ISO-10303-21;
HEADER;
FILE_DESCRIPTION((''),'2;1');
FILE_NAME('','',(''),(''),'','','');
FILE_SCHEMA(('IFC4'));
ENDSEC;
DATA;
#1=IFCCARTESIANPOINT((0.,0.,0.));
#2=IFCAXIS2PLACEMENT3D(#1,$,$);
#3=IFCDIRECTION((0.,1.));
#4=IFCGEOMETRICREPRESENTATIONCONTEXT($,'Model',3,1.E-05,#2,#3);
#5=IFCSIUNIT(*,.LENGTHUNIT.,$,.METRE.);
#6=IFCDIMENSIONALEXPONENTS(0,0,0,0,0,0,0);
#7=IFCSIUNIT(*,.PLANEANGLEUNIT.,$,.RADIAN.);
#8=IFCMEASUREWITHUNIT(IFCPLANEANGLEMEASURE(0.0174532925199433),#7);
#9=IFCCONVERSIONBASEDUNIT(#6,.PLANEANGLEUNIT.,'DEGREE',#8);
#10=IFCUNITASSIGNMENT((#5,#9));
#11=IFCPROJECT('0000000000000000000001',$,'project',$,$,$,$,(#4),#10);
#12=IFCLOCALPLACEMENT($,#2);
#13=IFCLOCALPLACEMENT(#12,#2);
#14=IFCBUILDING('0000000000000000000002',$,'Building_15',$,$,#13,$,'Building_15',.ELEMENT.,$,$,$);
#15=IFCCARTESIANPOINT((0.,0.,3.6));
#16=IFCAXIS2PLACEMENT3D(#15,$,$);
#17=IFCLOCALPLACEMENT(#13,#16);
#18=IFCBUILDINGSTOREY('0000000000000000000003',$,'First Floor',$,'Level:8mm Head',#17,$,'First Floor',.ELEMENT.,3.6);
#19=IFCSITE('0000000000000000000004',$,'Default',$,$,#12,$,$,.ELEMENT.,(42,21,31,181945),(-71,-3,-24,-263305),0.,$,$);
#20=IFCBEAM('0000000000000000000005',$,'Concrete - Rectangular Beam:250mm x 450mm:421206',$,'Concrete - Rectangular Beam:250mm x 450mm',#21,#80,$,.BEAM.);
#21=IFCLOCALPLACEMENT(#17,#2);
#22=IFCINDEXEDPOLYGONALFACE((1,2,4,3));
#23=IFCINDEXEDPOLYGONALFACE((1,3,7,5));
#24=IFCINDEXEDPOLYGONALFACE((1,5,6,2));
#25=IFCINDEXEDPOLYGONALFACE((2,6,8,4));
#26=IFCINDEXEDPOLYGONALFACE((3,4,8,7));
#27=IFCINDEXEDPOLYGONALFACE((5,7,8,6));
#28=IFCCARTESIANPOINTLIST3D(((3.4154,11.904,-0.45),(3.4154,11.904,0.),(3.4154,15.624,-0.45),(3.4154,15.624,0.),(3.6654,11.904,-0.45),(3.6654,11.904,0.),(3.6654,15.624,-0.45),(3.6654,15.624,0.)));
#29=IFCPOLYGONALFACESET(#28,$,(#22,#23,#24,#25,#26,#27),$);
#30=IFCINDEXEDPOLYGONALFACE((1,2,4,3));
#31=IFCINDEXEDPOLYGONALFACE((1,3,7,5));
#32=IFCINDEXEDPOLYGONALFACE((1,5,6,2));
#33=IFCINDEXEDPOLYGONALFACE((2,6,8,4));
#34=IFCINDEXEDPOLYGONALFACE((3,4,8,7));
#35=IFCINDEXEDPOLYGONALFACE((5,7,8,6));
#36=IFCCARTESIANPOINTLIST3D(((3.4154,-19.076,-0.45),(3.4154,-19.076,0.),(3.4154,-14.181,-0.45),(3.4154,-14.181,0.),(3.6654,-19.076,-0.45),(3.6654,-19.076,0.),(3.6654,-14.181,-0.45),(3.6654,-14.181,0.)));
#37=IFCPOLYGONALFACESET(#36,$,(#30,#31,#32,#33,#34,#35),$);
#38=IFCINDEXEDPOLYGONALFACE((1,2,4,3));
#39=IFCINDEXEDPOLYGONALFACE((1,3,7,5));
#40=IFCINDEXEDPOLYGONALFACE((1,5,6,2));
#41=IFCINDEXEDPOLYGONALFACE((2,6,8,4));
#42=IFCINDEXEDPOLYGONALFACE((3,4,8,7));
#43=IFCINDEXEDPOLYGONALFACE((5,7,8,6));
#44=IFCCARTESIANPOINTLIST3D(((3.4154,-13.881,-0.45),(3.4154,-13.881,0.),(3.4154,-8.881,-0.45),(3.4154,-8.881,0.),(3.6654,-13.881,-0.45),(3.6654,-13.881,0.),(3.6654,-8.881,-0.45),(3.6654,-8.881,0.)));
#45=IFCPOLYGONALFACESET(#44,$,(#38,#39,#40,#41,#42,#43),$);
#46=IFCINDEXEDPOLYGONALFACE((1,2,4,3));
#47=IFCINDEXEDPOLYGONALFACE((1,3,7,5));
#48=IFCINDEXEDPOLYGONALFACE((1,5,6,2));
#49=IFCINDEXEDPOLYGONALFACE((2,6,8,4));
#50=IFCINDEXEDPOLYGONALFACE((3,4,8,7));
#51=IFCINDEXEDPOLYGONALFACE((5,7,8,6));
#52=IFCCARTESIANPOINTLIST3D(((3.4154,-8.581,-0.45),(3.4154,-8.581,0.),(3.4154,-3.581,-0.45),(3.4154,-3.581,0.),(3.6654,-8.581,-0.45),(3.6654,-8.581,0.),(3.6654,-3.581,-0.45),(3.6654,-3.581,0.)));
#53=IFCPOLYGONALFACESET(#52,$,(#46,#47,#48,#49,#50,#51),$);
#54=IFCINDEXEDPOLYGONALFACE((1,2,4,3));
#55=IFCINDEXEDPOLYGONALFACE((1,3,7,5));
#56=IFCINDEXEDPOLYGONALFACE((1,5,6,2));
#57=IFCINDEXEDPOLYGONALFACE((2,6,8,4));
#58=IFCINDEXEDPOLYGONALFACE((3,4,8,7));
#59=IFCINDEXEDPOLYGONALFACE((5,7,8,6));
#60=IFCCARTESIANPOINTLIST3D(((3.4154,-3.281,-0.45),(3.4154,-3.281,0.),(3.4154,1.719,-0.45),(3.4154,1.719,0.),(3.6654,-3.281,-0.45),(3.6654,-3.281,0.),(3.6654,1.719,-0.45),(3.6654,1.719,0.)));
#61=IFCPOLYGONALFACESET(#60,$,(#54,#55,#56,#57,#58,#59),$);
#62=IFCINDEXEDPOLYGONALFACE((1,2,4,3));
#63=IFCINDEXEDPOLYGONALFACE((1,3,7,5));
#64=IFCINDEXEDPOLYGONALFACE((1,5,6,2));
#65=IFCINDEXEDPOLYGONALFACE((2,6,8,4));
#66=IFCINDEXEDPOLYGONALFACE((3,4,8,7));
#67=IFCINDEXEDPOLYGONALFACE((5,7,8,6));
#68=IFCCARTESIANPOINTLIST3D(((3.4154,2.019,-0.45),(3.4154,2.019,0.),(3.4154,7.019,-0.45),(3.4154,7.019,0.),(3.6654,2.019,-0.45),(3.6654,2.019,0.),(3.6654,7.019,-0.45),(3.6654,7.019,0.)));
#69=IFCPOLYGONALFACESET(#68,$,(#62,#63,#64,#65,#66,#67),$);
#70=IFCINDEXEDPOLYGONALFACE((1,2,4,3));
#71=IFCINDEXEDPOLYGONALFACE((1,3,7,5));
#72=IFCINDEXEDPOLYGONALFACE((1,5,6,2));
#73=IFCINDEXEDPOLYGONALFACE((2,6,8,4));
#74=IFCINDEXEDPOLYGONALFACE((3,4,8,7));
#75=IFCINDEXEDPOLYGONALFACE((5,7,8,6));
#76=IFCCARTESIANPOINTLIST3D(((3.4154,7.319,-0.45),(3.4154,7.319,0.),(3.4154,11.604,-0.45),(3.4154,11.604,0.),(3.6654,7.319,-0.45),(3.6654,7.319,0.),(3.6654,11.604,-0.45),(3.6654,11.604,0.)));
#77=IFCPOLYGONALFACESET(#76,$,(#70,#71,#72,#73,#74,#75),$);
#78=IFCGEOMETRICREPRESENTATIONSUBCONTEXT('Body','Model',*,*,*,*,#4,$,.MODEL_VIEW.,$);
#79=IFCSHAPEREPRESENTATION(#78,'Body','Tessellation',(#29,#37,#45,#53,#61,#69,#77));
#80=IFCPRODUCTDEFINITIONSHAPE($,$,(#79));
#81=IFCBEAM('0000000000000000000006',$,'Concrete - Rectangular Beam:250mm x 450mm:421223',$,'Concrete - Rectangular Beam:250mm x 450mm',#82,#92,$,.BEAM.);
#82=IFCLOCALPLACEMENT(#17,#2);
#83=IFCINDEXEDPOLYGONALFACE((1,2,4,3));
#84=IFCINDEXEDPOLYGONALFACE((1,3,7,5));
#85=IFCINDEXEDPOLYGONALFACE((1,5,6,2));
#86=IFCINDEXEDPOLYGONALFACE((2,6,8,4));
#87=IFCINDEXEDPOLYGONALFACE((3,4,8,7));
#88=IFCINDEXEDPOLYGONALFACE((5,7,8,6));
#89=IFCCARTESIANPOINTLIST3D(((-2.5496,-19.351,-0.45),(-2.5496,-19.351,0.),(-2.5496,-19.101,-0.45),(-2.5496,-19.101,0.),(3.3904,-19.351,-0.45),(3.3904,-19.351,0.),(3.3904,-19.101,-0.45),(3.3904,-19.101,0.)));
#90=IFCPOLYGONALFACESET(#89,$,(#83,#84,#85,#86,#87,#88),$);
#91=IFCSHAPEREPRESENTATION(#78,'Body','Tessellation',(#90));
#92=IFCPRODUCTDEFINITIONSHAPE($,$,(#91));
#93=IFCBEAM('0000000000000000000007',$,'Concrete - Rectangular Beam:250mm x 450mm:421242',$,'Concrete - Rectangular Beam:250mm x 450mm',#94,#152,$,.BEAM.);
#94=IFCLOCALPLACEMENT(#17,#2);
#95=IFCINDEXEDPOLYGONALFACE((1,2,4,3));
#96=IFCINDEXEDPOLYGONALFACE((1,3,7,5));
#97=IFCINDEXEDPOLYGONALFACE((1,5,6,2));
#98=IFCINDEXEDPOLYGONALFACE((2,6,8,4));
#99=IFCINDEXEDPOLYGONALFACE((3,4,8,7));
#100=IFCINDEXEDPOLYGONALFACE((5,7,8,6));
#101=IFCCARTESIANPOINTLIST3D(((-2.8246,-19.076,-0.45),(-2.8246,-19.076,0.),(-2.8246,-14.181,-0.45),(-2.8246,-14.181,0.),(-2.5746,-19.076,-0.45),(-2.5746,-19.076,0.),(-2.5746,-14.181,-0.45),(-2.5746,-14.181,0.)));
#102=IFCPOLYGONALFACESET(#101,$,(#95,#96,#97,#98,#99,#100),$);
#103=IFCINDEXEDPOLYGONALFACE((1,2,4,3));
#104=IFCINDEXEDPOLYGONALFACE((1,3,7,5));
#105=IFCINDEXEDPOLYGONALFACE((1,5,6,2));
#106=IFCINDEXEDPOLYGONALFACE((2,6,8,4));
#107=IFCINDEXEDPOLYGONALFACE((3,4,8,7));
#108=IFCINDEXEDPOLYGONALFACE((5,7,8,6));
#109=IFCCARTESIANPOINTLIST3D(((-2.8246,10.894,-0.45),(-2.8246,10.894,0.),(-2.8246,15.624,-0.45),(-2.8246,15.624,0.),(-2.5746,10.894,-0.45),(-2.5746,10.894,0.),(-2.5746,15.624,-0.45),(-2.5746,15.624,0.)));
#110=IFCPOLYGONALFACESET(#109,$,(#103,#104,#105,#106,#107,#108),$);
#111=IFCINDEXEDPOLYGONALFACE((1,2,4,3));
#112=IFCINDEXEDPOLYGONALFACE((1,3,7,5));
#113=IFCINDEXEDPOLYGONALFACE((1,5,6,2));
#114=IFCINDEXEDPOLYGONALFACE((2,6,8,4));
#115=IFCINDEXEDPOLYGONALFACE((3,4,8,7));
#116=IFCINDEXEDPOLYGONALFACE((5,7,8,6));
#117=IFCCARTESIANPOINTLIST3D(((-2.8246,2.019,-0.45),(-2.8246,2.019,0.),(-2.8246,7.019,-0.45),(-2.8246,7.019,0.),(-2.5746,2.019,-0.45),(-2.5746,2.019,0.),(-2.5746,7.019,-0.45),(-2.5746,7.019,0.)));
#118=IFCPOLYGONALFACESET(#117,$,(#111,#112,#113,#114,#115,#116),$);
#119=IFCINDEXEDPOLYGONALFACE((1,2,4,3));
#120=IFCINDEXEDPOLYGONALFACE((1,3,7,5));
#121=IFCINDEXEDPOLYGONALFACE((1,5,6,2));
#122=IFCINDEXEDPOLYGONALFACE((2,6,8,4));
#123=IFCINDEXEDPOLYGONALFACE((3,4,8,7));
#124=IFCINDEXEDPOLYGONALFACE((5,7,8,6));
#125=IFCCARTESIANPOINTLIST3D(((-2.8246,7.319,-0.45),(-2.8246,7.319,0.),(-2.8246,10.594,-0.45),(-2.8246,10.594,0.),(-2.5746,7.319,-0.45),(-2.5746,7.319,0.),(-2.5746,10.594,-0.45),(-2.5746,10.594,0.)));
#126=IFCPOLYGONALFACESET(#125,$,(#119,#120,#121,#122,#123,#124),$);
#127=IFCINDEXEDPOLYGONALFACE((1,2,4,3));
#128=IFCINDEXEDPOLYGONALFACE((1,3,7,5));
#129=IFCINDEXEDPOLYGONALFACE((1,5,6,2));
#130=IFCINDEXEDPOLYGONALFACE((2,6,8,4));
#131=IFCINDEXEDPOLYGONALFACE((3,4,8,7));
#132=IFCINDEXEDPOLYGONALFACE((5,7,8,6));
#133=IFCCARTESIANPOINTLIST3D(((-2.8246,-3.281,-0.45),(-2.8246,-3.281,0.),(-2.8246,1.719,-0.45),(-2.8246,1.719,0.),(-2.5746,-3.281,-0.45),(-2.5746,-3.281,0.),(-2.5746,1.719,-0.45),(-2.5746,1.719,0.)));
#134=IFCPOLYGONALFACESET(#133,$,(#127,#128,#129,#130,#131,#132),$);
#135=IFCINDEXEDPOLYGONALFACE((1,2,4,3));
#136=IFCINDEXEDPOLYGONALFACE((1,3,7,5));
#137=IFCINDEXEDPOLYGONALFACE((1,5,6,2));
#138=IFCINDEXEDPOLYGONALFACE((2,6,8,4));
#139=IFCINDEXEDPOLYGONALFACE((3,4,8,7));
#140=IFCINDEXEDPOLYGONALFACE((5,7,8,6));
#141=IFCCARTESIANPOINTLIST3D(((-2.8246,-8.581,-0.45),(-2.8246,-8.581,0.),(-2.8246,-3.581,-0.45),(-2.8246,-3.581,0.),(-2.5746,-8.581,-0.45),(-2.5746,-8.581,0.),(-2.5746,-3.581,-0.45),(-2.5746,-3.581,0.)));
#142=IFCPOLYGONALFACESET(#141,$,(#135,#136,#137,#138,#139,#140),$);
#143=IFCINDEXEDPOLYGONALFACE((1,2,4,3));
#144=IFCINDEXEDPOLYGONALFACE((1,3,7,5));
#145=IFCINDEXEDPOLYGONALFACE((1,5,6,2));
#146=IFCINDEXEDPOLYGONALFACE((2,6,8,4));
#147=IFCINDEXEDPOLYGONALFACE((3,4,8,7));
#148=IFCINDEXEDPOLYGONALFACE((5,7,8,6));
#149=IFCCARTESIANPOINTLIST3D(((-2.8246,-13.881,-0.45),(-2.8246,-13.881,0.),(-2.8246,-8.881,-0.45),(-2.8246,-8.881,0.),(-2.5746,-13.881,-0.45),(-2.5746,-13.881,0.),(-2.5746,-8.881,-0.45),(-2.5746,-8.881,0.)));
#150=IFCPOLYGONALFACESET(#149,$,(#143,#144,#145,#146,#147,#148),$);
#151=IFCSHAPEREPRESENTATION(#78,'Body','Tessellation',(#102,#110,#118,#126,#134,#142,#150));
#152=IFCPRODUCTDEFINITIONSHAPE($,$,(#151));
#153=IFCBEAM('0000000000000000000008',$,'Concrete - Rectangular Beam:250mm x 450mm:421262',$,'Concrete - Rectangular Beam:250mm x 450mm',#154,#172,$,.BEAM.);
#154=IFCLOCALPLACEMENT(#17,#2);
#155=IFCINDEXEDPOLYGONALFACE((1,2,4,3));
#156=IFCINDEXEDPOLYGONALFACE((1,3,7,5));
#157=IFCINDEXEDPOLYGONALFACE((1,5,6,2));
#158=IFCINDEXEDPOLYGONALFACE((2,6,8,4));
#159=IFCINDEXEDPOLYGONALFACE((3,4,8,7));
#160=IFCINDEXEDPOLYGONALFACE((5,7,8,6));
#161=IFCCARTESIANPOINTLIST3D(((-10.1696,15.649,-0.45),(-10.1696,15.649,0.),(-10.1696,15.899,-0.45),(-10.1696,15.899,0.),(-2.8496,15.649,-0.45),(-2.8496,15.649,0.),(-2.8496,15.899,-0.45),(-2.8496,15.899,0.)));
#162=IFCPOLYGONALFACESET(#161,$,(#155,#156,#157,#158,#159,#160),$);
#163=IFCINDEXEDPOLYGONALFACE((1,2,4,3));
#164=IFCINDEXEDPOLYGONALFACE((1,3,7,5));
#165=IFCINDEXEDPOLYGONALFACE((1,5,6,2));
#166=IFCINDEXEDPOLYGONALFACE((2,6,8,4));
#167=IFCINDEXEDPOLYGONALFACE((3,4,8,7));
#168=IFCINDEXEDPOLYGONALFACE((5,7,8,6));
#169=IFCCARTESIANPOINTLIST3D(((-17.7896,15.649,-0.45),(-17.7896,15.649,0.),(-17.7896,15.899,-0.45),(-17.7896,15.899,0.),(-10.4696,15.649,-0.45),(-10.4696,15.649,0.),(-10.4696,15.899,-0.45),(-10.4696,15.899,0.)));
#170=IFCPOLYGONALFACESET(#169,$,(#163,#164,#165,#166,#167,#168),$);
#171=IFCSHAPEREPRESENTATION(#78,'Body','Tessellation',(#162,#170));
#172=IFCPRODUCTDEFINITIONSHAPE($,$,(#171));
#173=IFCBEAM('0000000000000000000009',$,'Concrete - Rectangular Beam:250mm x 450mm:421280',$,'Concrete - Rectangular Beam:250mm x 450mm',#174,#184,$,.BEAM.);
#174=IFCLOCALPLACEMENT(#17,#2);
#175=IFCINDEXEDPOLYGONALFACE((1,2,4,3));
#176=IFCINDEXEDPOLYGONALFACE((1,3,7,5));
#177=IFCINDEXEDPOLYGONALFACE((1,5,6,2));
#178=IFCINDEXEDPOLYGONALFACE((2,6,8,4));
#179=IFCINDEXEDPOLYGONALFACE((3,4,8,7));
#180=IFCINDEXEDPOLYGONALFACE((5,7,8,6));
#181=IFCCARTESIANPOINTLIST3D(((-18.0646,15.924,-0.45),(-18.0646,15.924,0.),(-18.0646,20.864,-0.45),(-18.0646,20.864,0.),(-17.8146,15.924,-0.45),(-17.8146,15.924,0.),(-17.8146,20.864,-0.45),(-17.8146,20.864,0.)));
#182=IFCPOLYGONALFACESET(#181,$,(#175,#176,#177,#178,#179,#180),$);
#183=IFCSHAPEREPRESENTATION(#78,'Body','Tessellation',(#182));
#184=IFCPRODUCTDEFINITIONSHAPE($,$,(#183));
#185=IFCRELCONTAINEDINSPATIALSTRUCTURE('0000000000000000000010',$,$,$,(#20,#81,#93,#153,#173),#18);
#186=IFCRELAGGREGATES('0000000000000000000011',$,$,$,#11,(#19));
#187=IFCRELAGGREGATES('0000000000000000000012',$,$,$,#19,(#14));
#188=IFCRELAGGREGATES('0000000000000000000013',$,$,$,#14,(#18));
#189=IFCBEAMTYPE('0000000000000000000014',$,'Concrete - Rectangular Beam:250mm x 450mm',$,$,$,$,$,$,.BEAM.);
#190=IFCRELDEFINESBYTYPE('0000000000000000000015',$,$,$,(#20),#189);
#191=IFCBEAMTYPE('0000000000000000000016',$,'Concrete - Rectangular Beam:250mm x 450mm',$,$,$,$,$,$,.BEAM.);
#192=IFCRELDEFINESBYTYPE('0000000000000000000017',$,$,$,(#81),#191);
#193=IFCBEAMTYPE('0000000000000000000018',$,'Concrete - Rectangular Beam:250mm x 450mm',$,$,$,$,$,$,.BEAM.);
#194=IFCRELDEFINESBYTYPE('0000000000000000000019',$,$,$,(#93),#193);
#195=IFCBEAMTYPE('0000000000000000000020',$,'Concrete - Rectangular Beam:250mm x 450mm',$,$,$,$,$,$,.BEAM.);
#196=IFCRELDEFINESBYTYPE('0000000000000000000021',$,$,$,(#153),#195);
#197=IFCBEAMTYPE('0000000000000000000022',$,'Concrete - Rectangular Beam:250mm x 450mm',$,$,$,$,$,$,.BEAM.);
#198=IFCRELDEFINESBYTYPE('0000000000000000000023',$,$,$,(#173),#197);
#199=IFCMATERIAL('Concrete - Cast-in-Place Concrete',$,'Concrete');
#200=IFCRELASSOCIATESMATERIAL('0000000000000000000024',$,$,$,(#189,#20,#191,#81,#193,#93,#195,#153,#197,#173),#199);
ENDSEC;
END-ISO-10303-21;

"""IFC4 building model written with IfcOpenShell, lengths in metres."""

from ifc_helpers import new_model, entity, si_unit, converted_unit, direction, frame, origin, place, context, subcontext, project, spatial, indexed_curve, outline, extrude, source, transform, mapped, material, type_object, type_shapes, element, save


model = new_model("IFC4")

# Units and contexts
model_context = context("Model", 3, precision=1e-05, world=origin(), true_north=direction((0.0, 1.0)))
body_context = subcontext(model_context, "Body", "Model", "MODEL_VIEW")
ifc_project = project(units=[si_unit("LENGTHUNIT", "METRE"), converted_unit("PLANEANGLEUNIT", "DEGREE", entity("IfcPlaneAngleMeasure", 0.0174532925199433), si_unit("PLANEANGLEUNIT", "RADIAN"), dimensions=[0, 0, 0, 0, 0, 0, 0])], contexts=[model_context])

# Site, building, storey
site_placement = place(None, origin())
site = spatial("IfcSite", under=ifc_project, at=site_placement, Name="Default", CompositionType="ELEMENT", RefLatitude=(42, 21, 31, 181945), RefLongitude=(-71, -3, -24, -263305), RefElevation=0.0)
building_placement = place(site_placement, origin())
building = spatial("IfcBuilding", under=site, at=building_placement, Name="Building_15", LongName="Building_15", CompositionType="ELEMENT")
storey_placement = place(building_placement, frame((0.0, 0.0, 3.6)))
storey = spatial("IfcBuildingStorey", under=building, at=storey_placement, Name="First Floor", ObjectType="Level:8mm Head", LongName="First Floor", CompositionType="ELEMENT", Elevation=3.6)

# Beams
ifc_material_1 = material(Name="Concrete - Cast-in-Place Concrete", Category="Concrete")
beam_type_1 = type_object("IfcBeamType", Name="Concrete - Rectangular Beam:250mm x 450mm", PredefinedType="BEAM", material=ifc_material_1)
shared_shape_1 = source(origin(), body_context, "Body", "SweptSolid", [
    extrude(outline(indexed_curve([(-0.125, -0.225), (0.125, -0.225), (0.125, 0.225), (-0.125, 0.225), (-0.125, -0.225)], self_intersect=False)), frame((3.5404, 15.624, 3.375), z_axis=(0.0, -1.0, 0.0), x_axis=(-1.0, 0.0, 0.0)), (0.0, 0.0, 1.0), 3.72),
    extrude(outline(indexed_curve([(-0.125, -0.225), (0.125, -0.225), (0.125, 0.225), (-0.125, 0.225), (-0.125, -0.225)], self_intersect=False)), frame((3.5404, -14.181, 3.375), z_axis=(0.0, -1.0, 0.0), x_axis=(-1.0, 0.0, 0.0)), (0.0, 0.0, 1.0), 4.895),
    extrude(outline(indexed_curve([(-0.125, -0.225), (0.125, -0.225), (0.125, 0.225), (-0.125, 0.225), (-0.125, -0.225)], self_intersect=False)), frame((3.5404, -8.881, 3.375), z_axis=(0.0, -1.0, 0.0), x_axis=(-1.0, 0.0, 0.0)), (0.0, 0.0, 1.0), 5.0),
    extrude(outline(indexed_curve([(-0.125, -0.225), (0.125, -0.225), (0.125, 0.225), (-0.125, 0.225), (-0.125, -0.225)], self_intersect=False)), frame((3.5404, -3.581, 3.375), z_axis=(0.0, -1.0, 0.0), x_axis=(-1.0, 0.0, 0.0)), (0.0, 0.0, 1.0), 5.0),
    extrude(outline(indexed_curve([(-0.125, -0.225), (0.125, -0.225), (0.125, 0.225), (-0.125, 0.225), (-0.125, -0.225)], self_intersect=False)), frame((3.5404, 1.719, 3.375), z_axis=(0.0, -1.0, 0.0), x_axis=(-1.0, 0.0, 0.0)), (0.0, 0.0, 1.0), 5.0),
    extrude(outline(indexed_curve([(-0.125, -0.225), (0.125, -0.225), (0.125, 0.225), (-0.125, 0.225), (-0.125, -0.225)], self_intersect=False)), frame((3.5404, 7.019, 3.375), z_axis=(0.0, -1.0, 0.0), x_axis=(-1.0, 0.0, 0.0)), (0.0, 0.0, 1.0), 5.0),
    extrude(outline(indexed_curve([(-0.125, -0.225), (0.125, -0.225), (0.125, 0.225), (-0.125, 0.225), (-0.125, -0.225)], self_intersect=False)), frame((3.5404, 11.604, 3.375), z_axis=(0.0, -1.0, 0.0), x_axis=(-1.0, 0.0, 0.0)), (0.0, 0.0, 1.0), 4.285),
])
type_shapes(beam_type_1, [shared_shape_1])
beam_1_placement = place(storey_placement, frame((0.0, 0.0, -3.6)))
element("IfcBeam", 1, at=beam_1_placement, inside=storey, type_object=beam_type_1, material=ifc_material_1, Name="Concrete - Rectangular Beam:250mm x 450mm:421206", ObjectType="Concrete - Rectangular Beam:250mm x 450mm", PredefinedType="BEAM", context=body_context, shape_type="MappedRepresentation", body=[
    mapped(shared_shape_1, transform((0.0, 0.0, 0.0), scale=1.0)),
])
beam_type_2 = type_object("IfcBeamType", Name="Concrete - Rectangular Beam:250mm x 450mm", PredefinedType="BEAM", material=ifc_material_1)
shared_shape_2 = source(origin(), body_context, "Body", "SweptSolid", [
    extrude(outline(indexed_curve([(-0.225, -0.125), (0.225, -0.125), (0.225, 0.125), (-0.225, 0.125), (-0.225, -0.125)], self_intersect=False)), frame((3.3904, -19.226, 3.375), z_axis=(-1.0, 0.0, 0.0), x_axis=(0.0, 0.0, -1.0)), (0.0, 0.0, 1.0), 5.94),
])
type_shapes(beam_type_2, [shared_shape_2])
beam_2_placement = place(storey_placement, frame((0.0, 0.0, -3.6)))
element("IfcBeam", 2, at=beam_2_placement, inside=storey, type_object=beam_type_2, material=ifc_material_1, Name="Concrete - Rectangular Beam:250mm x 450mm:421223", ObjectType="Concrete - Rectangular Beam:250mm x 450mm", PredefinedType="BEAM", context=body_context, shape_type="MappedRepresentation", body=[
    mapped(shared_shape_2, transform((0.0, 0.0, 0.0), scale=1.0)),
])
beam_type_3 = type_object("IfcBeamType", Name="Concrete - Rectangular Beam:250mm x 450mm", PredefinedType="BEAM", material=ifc_material_1)
shared_shape_3 = source(origin(), body_context, "Body", "SweptSolid", [
    extrude(outline(indexed_curve([(-0.125, -0.225), (0.125, -0.225), (0.125, 0.225), (-0.125, 0.225), (-0.125, -0.225)], self_intersect=False)), frame((-2.6996, -19.076, 3.375), z_axis=(0.0, 1.0, 0.0), x_axis=(-1.0, 0.0, 0.0)), (0.0, 0.0, 1.0), 4.895),
    extrude(outline(indexed_curve([(-0.125, -0.225), (0.125, -0.225), (0.125, 0.225), (-0.125, 0.225), (-0.125, -0.225)], self_intersect=False)), frame((-2.6996, 10.894, 3.375), z_axis=(0.0, 1.0, 0.0), x_axis=(-1.0, 0.0, 0.0)), (0.0, 0.0, 1.0), 4.73),
    extrude(outline(indexed_curve([(-0.125, -0.225), (0.125, -0.225), (0.125, 0.225), (-0.125, 0.225), (-0.125, -0.225)], self_intersect=False)), frame((-2.6996, 2.019, 3.375), z_axis=(0.0, 1.0, 0.0), x_axis=(-1.0, 0.0, 0.0)), (0.0, 0.0, 1.0), 5.0),
    extrude(outline(indexed_curve([(-0.125, -0.225), (0.125, -0.225), (0.125, 0.225), (-0.125, 0.225), (-0.125, -0.225)], self_intersect=False)), frame((-2.6996, 7.319, 3.375), z_axis=(0.0, 1.0, 0.0), x_axis=(-1.0, 0.0, 0.0)), (0.0, 0.0, 1.0), 3.275),
    extrude(outline(indexed_curve([(-0.125, -0.225), (0.125, -0.225), (0.125, 0.225), (-0.125, 0.225), (-0.125, -0.225)], self_intersect=False)), frame((-2.6996, -3.281, 3.375), z_axis=(0.0, 1.0, 0.0), x_axis=(-1.0, 0.0, 0.0)), (0.0, 0.0, 1.0), 5.0),
    extrude(outline(indexed_curve([(-0.125, -0.225), (0.125, -0.225), (0.125, 0.225), (-0.125, 0.225), (-0.125, -0.225)], self_intersect=False)), frame((-2.6996, -8.581, 3.375), z_axis=(0.0, 1.0, 0.0), x_axis=(-1.0, 0.0, 0.0)), (0.0, 0.0, 1.0), 5.0),
    extrude(outline(indexed_curve([(-0.125, -0.225), (0.125, -0.225), (0.125, 0.225), (-0.125, 0.225), (-0.125, -0.225)], self_intersect=False)), frame((-2.6996, -13.881, 3.375), z_axis=(0.0, 1.0, 0.0), x_axis=(-1.0, 0.0, 0.0)), (0.0, 0.0, 1.0), 5.0),
])
type_shapes(beam_type_3, [shared_shape_3])
beam_3_placement = place(storey_placement, frame((0.0, 0.0, -3.6)))
element("IfcBeam", 3, at=beam_3_placement, inside=storey, type_object=beam_type_3, material=ifc_material_1, Name="Concrete - Rectangular Beam:250mm x 450mm:421242", ObjectType="Concrete - Rectangular Beam:250mm x 450mm", PredefinedType="BEAM", context=body_context, shape_type="MappedRepresentation", body=[
    mapped(shared_shape_3, transform((0.0, 0.0, 0.0), scale=1.0)),
])
beam_type_4 = type_object("IfcBeamType", Name="Concrete - Rectangular Beam:250mm x 450mm", PredefinedType="BEAM", material=ifc_material_1)
shared_shape_4 = source(origin(), body_context, "Body", "SweptSolid", [
    extrude(outline(indexed_curve([(-0.225, -0.125), (0.225, -0.125), (0.225, 0.125), (-0.225, 0.125), (-0.225, -0.125)], self_intersect=False)), frame((-2.8496, 15.774, 3.375), z_axis=(-1.0, 0.0, 0.0), x_axis=(0.0, 0.0, -1.0)), (0.0, 0.0, 1.0), 7.32),
    extrude(outline(indexed_curve([(-0.225, -0.125), (0.225, -0.125), (0.225, 0.125), (-0.225, 0.125), (-0.225, -0.125)], self_intersect=False)), frame((-10.4696, 15.774, 3.375), z_axis=(-1.0, 0.0, 0.0), x_axis=(0.0, 0.0, -1.0)), (0.0, 0.0, 1.0), 7.32),
])
type_shapes(beam_type_4, [shared_shape_4])
beam_4_placement = place(storey_placement, frame((0.0, 0.0, -3.6)))
element("IfcBeam", 4, at=beam_4_placement, inside=storey, type_object=beam_type_4, material=ifc_material_1, Name="Concrete - Rectangular Beam:250mm x 450mm:421262", ObjectType="Concrete - Rectangular Beam:250mm x 450mm", PredefinedType="BEAM", context=body_context, shape_type="MappedRepresentation", body=[
    mapped(shared_shape_4, transform((0.0, 0.0, 0.0), scale=1.0)),
])
beam_type_5 = type_object("IfcBeamType", Name="Concrete - Rectangular Beam:250mm x 450mm", PredefinedType="BEAM", material=ifc_material_1)
shared_shape_5 = source(origin(), body_context, "Body", "SweptSolid", [
    extrude(outline(indexed_curve([(-0.125, -0.225), (0.125, -0.225), (0.125, 0.225), (-0.125, 0.225), (-0.125, -0.225)], self_intersect=False)), frame((-17.9396, 15.924, 3.375), z_axis=(0.0, 1.0, 0.0), x_axis=(-1.0, 0.0, 0.0)), (0.0, 0.0, 1.0), 4.94),
])
type_shapes(beam_type_5, [shared_shape_5])
beam_5_placement = place(storey_placement, frame((0.0, 0.0, -3.6)))
element("IfcBeam", 5, at=beam_5_placement, inside=storey, type_object=beam_type_5, material=ifc_material_1, Name="Concrete - Rectangular Beam:250mm x 450mm:421280", ObjectType="Concrete - Rectangular Beam:250mm x 450mm", PredefinedType="BEAM", context=body_context, shape_type="MappedRepresentation", body=[
    mapped(shared_shape_5, transform((0.0, 0.0, 0.0), scale=1.0)),
])

save(model, "model.ifc")
